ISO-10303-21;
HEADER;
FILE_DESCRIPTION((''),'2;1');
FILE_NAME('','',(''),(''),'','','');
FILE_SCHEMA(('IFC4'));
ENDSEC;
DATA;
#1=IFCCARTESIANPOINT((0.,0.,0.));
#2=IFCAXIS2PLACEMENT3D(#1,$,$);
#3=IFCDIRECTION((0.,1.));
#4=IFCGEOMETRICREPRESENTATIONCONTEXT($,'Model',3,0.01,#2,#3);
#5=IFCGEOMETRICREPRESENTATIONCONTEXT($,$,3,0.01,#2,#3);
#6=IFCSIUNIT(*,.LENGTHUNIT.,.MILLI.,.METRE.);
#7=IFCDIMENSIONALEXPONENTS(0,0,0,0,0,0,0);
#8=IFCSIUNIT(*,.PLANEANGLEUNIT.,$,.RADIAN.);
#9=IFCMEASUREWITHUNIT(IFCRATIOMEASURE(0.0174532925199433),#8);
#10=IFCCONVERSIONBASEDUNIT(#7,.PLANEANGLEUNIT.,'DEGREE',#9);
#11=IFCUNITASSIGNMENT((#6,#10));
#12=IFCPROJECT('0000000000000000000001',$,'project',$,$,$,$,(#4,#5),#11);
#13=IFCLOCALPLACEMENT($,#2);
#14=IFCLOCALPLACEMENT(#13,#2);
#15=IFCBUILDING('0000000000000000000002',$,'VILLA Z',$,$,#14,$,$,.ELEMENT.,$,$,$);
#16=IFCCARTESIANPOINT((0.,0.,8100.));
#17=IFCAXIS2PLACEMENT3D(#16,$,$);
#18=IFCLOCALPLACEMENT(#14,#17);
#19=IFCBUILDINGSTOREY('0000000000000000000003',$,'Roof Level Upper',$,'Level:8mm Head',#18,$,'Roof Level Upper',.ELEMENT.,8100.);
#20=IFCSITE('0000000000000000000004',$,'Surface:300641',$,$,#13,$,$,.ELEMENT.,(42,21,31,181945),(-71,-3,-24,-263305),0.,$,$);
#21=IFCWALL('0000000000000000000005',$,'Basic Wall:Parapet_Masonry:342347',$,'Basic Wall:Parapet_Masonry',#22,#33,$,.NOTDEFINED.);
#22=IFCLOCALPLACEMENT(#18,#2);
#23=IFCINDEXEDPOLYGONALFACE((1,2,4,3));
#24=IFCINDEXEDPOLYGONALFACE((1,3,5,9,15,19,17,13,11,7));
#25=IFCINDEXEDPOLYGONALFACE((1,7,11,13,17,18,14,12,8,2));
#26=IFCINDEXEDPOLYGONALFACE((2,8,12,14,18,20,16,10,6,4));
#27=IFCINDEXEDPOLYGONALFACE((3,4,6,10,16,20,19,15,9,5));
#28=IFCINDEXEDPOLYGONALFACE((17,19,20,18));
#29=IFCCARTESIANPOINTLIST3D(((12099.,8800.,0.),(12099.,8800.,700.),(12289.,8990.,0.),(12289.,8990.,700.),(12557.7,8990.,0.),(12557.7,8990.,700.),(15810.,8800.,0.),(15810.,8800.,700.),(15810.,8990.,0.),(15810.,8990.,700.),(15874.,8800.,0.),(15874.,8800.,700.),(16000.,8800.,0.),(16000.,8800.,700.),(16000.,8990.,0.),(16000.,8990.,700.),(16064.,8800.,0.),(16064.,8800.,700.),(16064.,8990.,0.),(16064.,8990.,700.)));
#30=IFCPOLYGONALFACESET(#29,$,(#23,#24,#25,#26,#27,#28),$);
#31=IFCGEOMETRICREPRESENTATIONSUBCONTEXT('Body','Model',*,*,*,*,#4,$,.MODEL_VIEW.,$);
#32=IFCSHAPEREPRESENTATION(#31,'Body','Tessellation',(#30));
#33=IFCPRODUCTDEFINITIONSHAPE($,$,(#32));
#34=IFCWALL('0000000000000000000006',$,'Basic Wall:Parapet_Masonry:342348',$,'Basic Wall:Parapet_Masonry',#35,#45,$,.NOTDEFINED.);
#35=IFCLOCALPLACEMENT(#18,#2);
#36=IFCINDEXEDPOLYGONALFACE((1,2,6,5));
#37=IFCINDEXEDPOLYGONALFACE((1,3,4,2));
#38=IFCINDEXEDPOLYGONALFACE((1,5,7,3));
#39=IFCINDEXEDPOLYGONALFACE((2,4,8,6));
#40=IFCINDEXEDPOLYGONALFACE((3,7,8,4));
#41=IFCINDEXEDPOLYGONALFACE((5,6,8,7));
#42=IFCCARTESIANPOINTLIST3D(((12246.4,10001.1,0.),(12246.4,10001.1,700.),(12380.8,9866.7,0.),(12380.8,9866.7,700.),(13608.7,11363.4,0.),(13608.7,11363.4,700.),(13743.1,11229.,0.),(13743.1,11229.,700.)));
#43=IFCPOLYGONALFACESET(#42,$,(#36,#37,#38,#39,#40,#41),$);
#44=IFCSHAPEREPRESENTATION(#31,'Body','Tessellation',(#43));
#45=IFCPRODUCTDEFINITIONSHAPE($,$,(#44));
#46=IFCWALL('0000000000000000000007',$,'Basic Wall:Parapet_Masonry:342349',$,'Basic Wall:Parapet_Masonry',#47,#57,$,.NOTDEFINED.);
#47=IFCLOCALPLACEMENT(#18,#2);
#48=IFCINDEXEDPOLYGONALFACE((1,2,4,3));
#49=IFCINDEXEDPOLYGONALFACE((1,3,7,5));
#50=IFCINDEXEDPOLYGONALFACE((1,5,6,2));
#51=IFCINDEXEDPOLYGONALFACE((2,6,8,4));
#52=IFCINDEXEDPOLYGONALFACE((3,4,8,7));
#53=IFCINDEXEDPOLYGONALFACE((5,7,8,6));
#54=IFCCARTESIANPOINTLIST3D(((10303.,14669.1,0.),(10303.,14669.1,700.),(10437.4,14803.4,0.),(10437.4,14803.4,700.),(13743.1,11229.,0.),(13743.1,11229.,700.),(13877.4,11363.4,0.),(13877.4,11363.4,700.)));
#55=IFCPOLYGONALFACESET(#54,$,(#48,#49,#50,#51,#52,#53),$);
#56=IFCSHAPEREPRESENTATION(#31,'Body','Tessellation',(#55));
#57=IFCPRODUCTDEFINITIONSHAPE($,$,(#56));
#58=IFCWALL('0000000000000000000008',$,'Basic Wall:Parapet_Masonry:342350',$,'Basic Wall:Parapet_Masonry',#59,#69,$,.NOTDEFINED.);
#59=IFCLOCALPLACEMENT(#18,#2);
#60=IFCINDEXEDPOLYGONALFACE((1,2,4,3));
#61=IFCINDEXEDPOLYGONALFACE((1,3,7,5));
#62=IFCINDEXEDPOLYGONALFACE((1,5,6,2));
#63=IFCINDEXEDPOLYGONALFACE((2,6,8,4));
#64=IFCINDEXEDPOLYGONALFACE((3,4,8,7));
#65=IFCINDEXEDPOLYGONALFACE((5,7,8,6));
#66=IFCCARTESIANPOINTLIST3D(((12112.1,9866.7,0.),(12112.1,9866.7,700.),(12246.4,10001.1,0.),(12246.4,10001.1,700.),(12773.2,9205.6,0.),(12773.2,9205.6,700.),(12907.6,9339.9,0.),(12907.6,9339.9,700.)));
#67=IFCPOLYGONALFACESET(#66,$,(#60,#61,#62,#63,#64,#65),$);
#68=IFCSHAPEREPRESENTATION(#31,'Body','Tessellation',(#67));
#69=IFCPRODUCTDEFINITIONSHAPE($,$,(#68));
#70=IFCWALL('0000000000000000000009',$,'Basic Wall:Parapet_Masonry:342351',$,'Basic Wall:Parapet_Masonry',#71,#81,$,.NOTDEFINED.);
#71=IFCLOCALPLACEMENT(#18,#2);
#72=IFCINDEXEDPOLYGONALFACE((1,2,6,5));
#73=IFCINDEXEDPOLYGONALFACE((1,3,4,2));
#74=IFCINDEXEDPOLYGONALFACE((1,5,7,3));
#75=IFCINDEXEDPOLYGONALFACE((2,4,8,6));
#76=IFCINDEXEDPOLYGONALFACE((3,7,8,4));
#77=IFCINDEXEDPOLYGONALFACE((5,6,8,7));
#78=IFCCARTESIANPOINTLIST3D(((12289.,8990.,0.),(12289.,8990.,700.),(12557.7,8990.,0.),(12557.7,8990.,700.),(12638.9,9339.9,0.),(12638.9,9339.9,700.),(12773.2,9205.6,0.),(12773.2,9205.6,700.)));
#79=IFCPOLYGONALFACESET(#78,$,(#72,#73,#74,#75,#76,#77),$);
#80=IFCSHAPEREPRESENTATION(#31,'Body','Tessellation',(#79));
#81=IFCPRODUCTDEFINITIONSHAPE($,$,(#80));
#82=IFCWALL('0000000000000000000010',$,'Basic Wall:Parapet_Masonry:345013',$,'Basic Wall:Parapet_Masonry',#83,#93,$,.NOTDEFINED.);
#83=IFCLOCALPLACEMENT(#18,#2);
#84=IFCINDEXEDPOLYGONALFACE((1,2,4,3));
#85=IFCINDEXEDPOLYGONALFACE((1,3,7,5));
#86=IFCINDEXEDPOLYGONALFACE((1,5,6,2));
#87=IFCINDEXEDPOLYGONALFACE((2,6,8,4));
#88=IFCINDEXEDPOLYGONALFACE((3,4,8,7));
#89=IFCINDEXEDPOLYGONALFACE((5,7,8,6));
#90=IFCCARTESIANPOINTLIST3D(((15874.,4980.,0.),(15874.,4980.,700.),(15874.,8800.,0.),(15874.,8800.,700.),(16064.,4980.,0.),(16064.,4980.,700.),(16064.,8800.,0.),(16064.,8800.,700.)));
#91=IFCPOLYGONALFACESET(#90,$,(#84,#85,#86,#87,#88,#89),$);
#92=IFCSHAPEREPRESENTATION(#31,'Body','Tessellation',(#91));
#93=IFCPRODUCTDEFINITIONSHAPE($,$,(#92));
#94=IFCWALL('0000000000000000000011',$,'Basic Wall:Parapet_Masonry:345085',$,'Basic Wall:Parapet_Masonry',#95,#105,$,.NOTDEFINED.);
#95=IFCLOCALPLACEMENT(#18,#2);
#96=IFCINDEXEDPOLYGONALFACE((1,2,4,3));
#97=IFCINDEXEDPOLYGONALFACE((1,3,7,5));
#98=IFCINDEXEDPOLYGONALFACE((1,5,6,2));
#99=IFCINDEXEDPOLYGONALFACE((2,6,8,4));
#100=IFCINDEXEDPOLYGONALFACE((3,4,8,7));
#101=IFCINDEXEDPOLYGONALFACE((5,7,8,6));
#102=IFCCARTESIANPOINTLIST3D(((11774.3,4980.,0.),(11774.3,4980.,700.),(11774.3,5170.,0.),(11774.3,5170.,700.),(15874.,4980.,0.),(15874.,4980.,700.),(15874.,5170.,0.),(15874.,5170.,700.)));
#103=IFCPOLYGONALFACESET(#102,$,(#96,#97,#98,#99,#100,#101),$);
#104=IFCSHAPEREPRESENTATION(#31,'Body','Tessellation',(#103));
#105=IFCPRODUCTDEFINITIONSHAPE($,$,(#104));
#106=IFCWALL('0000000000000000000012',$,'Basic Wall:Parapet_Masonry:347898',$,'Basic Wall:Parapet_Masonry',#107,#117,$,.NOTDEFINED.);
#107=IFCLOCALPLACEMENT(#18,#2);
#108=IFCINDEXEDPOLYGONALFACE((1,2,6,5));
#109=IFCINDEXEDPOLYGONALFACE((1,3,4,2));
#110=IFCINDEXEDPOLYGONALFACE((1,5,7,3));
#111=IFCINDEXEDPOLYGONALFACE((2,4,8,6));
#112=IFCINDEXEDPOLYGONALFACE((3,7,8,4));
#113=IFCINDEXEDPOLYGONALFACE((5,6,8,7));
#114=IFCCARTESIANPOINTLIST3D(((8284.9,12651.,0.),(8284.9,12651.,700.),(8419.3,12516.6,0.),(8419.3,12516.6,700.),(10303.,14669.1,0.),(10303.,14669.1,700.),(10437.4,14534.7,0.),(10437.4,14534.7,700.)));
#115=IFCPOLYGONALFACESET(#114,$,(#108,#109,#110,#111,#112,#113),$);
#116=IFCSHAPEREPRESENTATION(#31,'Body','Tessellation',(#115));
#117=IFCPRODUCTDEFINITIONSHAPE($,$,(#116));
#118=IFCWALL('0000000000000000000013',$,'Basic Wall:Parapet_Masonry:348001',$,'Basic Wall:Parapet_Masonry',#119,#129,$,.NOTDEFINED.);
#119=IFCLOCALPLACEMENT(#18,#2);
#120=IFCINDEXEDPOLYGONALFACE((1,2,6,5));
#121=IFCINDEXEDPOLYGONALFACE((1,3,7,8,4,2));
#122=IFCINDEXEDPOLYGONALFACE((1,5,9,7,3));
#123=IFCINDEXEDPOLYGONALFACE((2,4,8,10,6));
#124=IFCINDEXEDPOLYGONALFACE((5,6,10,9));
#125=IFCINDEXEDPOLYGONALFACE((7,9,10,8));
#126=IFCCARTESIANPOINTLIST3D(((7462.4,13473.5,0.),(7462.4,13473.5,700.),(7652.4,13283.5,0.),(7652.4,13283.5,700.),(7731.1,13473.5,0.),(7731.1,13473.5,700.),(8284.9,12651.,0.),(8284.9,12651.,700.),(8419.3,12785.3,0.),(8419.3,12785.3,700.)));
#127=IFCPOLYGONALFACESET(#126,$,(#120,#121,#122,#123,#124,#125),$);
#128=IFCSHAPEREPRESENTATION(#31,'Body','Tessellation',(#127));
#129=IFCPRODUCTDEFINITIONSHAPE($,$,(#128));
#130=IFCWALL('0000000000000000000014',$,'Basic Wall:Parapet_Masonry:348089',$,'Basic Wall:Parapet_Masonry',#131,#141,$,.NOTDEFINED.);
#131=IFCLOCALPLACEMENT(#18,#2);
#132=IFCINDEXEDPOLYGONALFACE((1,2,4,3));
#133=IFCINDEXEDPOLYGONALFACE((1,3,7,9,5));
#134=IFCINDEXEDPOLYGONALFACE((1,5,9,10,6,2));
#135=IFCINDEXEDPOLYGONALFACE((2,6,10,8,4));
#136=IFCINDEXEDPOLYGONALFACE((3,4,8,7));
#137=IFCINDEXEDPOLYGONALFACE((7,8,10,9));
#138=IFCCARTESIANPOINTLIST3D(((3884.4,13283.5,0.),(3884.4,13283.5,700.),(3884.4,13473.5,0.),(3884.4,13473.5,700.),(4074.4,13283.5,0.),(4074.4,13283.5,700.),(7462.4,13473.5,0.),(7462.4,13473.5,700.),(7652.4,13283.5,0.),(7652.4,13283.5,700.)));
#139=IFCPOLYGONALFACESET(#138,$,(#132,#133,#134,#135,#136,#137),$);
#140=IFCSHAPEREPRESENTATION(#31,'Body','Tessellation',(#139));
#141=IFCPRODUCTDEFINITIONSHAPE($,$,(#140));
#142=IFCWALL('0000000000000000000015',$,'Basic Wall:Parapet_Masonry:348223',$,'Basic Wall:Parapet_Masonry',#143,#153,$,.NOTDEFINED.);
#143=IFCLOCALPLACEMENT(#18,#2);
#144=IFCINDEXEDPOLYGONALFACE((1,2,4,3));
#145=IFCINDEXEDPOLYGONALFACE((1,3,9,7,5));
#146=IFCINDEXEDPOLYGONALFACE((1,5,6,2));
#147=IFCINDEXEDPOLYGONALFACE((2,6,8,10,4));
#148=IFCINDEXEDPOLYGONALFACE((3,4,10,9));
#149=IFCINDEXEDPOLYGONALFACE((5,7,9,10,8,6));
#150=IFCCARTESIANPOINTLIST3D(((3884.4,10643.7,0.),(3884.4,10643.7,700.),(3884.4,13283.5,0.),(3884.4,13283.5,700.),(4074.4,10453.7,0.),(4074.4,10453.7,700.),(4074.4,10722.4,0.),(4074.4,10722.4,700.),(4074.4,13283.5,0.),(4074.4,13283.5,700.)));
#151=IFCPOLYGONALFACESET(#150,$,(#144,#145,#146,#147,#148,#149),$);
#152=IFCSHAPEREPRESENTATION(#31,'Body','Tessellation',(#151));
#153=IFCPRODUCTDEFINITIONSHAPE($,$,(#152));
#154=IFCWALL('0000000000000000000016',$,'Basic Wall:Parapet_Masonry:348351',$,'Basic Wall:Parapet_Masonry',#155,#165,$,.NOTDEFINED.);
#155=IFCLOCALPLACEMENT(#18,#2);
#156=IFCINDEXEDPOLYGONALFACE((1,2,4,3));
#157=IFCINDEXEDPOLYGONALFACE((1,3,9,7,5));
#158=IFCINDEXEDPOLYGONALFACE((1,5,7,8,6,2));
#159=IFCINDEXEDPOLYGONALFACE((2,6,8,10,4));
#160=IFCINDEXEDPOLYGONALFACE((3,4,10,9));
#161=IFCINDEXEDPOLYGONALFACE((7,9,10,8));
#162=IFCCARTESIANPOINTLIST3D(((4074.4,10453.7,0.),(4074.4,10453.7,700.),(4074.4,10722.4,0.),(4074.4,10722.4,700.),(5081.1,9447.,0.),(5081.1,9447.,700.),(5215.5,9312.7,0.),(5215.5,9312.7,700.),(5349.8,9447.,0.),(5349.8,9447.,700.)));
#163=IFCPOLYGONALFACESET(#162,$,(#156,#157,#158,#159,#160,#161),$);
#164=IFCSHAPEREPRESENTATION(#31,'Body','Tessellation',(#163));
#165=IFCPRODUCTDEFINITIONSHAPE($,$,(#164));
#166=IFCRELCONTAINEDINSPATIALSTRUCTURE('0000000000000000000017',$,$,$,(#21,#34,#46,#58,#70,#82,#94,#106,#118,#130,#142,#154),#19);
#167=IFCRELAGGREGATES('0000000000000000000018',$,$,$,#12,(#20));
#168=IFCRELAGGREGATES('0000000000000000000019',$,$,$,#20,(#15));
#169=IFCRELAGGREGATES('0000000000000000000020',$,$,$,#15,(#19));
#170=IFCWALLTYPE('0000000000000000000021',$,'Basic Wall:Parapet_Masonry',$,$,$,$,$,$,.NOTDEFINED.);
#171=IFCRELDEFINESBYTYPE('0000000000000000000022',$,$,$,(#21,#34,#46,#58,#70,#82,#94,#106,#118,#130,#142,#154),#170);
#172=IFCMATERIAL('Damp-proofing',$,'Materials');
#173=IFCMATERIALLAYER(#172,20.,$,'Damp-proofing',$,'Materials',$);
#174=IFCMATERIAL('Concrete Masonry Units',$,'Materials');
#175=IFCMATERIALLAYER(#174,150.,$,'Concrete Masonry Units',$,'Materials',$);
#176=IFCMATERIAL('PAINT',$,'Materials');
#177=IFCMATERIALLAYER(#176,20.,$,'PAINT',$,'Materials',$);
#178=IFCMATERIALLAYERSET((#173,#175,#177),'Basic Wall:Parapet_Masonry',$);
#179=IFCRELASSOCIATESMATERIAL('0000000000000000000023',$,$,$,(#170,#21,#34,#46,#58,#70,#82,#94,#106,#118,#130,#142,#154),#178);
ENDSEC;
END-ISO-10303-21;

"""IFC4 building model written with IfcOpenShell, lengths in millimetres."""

from ifc_helpers import new_model, entity, si_unit, converted_unit, direction, frame, frame_2d, origin, place, context, subcontext, project, spatial, polyline, rectangle, outline, extrude, material, layer, layer_set, layer_usage, type_object, element, save


model = new_model("IFC4")

# Units and contexts
model_context = context("Model", 3, precision=0.01, world=origin(), true_north=direction((0.0, 1.0)))
context_of_model = context(None, 3, precision=0.01, world=origin(), true_north=direction((0.0, 1.0)))
body_context = subcontext(model_context, "Body", "Model", "MODEL_VIEW")
ifc_project = project(units=[si_unit("LENGTHUNIT", "METRE", prefix="MILLI"), converted_unit("PLANEANGLEUNIT", "DEGREE", entity("IfcRatioMeasure", 0.0174532925199433), si_unit("PLANEANGLEUNIT", "RADIAN"), dimensions=[0, 0, 0, 0, 0, 0, 0])], contexts=[model_context, context_of_model])

# Site, building, storey
site_placement = place(None, origin())
site = spatial("IfcSite", under=ifc_project, at=site_placement, Name="Surface:300641", CompositionType="ELEMENT", RefLatitude=(42, 21, 31, 181945), RefLongitude=(-71, -3, -24, -263305), RefElevation=0.0)
building_placement = place(site_placement, origin())
building = spatial("IfcBuilding", under=site, at=building_placement, Name="VILLA Z", CompositionType="ELEMENT")
storey_placement = place(building_placement, frame((0.0, 0.0, 8100.0)))
storey = spatial("IfcBuildingStorey", under=building, at=storey_placement, Name="Roof Level Upper", ObjectType="Level:8mm Head", LongName="Roof Level Upper", CompositionType="ELEMENT", Elevation=8100.0)

# Shared definitions
ifc_material_1 = material(Name="Damp-proofing", Category="Materials")

# Walls
ifc_layer_1 = layer(ifc_material_1, 20.0, Name="Damp-proofing", Category="Materials")
ifc_material_2 = material(Name="Concrete Masonry Units", Category="Materials")
ifc_layer_2 = layer(ifc_material_2, 150.0, Name="Concrete Masonry Units", Category="Materials")
ifc_material_3 = material(Name="PAINT", Category="Materials")
ifc_layer_3 = layer(ifc_material_3, 20.0, Name="PAINT", Category="Materials")
ifc_layer_set_1 = layer_set([ifc_layer_1, ifc_layer_2, ifc_layer_3], Name="Basic Wall:Parapet_Masonry")
ifc_layer_usage_1 = layer_usage(ifc_layer_set_1, "AXIS2", "NEGATIVE", 95.0)
wall_type = type_object("IfcWallType", Name="Basic Wall:Parapet_Masonry", PredefinedType="NOTDEFINED", material=ifc_layer_set_1)
wall_1_placement = place(storey_placement, frame((16064.0, 8895.0, 0.0), z_axis=(0.0, 0.0, 1.0), x_axis=(-1.0, 0.0, 0.0)))
element("IfcWall", 1, at=wall_1_placement, inside=storey, type_object=wall_type, material=ifc_layer_usage_1, Name="Basic Wall:Parapet_Masonry:342347", ObjectType="Basic Wall:Parapet_Masonry", PredefinedType="NOTDEFINED", context=body_context, shape_type="SweptSolid", body=[
    extrude(outline(polyline([(3775.0, -95.0), (3965.0, 95.0), (254.0, 95.0), (190.0, 95.0), (64.0, 95.0), (0.0, 95.0), (0.0, -95.0), (64.0, -95.0), (254.0, -95.0), (3506.3, -95.0), (3775.0, -95.0)])), origin(), (0.0, 0.0, 1.0), 700.0),
])
ifc_layer_usage_2 = layer_usage(ifc_layer_set_1, "AXIS2", "POSITIVE", -95.0)
wall_2_placement = place(storey_placement, frame((13675.9, 11296.2, 0.0), z_axis=(0.0, 0.0, 1.0), x_axis=(-0.707107, -0.707107, 0.0)))
element("IfcWall", 2, at=wall_2_placement, inside=storey, type_object=wall_type, material=ifc_layer_usage_2, Name="Basic Wall:Parapet_Masonry:342348", ObjectType="Basic Wall:Parapet_Masonry", PredefinedType="NOTDEFINED", context=body_context, shape_type="SweptSolid", body=[
    extrude(rectangle(XDim=1926.6, YDim=190.0, at=frame_2d((963.3, 0.0), x_axis=(-1.0, 0.0))), origin(), (0.0, 0.0, 1.0), 700.0),
])
ifc_layer_usage_3 = layer_usage(ifc_layer_set_1, "AXIS2", "POSITIVE", -95.0)
wall_3_placement = place(storey_placement, frame((10370.2, 14736.3, 0.0), z_axis=(0.0, 0.0, 1.0), x_axis=(0.707107, -0.707107, 0.0)))
element("IfcWall", 3, at=wall_3_placement, inside=storey, type_object=wall_type, material=ifc_layer_usage_3, Name="Basic Wall:Parapet_Masonry:342349", ObjectType="Basic Wall:Parapet_Masonry", PredefinedType="NOTDEFINED", context=body_context, shape_type="SweptSolid", body=[
    extrude(rectangle(XDim=4865.0, YDim=190.0, at=frame_2d((2432.5, 0.0), x_axis=(-1.0, 0.0))), origin(), (0.0, 0.0, 1.0), 700.0),
])
ifc_layer_usage_4 = layer_usage(ifc_layer_set_1, "AXIS2", "POSITIVE", -95.0)
wall_4_placement = place(storey_placement, frame((12179.3, 9933.9, 0.0), z_axis=(0.0, 0.0, 1.0), x_axis=(0.707107, -0.707107, 0.0)))
element("IfcWall", 4, at=wall_4_placement, inside=storey, type_object=wall_type, material=ifc_layer_usage_4, Name="Basic Wall:Parapet_Masonry:342350", ObjectType="Basic Wall:Parapet_Masonry", PredefinedType="NOTDEFINED", context=body_context, shape_type="SweptSolid", body=[
    extrude(rectangle(XDim=935.0, YDim=190.0, at=frame_2d((467.5, 0.0), x_axis=(-1.0, 0.0))), origin(), (0.0, 0.0, 1.0), 700.0),
])
ifc_layer_usage_5 = layer_usage(ifc_layer_set_1, "AXIS2", "POSITIVE", -95.0)
wall_5_placement = place(storey_placement, frame((12706.1, 9272.7, 0.0), z_axis=(0.0, 0.0, 1.0), x_axis=(-0.707107, -0.707107, 0.0)))
element("IfcWall", 5, at=wall_5_placement, inside=storey, type_object=wall_type, material=ifc_layer_usage_5, Name="Basic Wall:Parapet_Masonry:342351", ObjectType="Basic Wall:Parapet_Masonry", PredefinedType="NOTDEFINED", context=body_context, shape_type="SweptSolid", body=[
    extrude(outline(polyline([(494.8, -95.0), (304.8, 95.0), (0.0, 95.0), (0.0, -95.0), (494.8, -95.0)])), origin(), (0.0, 0.0, 1.0), 700.0),
])
ifc_layer_usage_6 = layer_usage(ifc_layer_set_1, "AXIS2", "POSITIVE", -95.0)
wall_6_placement = place(storey_placement, frame((15969.0, 8800.0, 0.0), z_axis=(0.0, 0.0, 1.0), x_axis=(0.0, -1.0, 0.0)))
element("IfcWall", 6, at=wall_6_placement, inside=storey, type_object=wall_type, material=ifc_layer_usage_6, Name="Basic Wall:Parapet_Masonry:345013", ObjectType="Basic Wall:Parapet_Masonry", PredefinedType="NOTDEFINED", context=body_context, shape_type="SweptSolid", body=[
    extrude(rectangle(XDim=3820.0, YDim=190.0, at=frame_2d((1910.0, 0.0), x_axis=(-1.0, 0.0))), origin(), (0.0, 0.0, 1.0), 700.0),
])
ifc_layer_usage_7 = layer_usage(ifc_layer_set_1, "AXIS2", "NEGATIVE", 95.0)
wall_7_placement = place(storey_placement, frame((11774.3, 5075.0, 0.0)))
element("IfcWall", 7, at=wall_7_placement, inside=storey, type_object=wall_type, material=ifc_layer_usage_7, Name="Basic Wall:Parapet_Masonry:345085", ObjectType="Basic Wall:Parapet_Masonry", PredefinedType="NOTDEFINED", context=body_context, shape_type="SweptSolid", body=[
    extrude(rectangle(XDim=4099.7, YDim=190.0, at=frame_2d((2049.9, 0.0), x_axis=(-1.0, 0.0))), origin(), (0.0, 0.0, 1.0), 700.0),
])
ifc_layer_usage_8 = layer_usage(ifc_layer_set_1, "AXIS2", "NEGATIVE", 95.0)
wall_8_placement = place(storey_placement, frame((10370.2, 14601.9, 0.0), z_axis=(0.0, 0.0, 1.0), x_axis=(-0.707107, -0.707107, 0.0)))
element("IfcWall", 8, at=wall_8_placement, inside=storey, type_object=wall_type, material=ifc_layer_usage_8, Name="Basic Wall:Parapet_Masonry:347898", ObjectType="Basic Wall:Parapet_Masonry", PredefinedType="NOTDEFINED", context=body_context, shape_type="SweptSolid", body=[
    extrude(rectangle(XDim=2854.0, YDim=190.0, at=frame_2d((1427.0, 0.0), x_axis=(-1.0, 0.0))), origin(), (0.0, 0.0, 1.0), 700.0),
])
ifc_layer_usage_9 = layer_usage(ifc_layer_set_1, "AXIS2", "POSITIVE", -95.0)
wall_9_placement = place(storey_placement, frame((7529.6, 13540.6, 0.0), z_axis=(0.0, 0.0, 1.0), x_axis=(0.707107, -0.707107, 0.0)))
element("IfcWall", 9, at=wall_9_placement, inside=storey, type_object=wall_type, material=ifc_layer_usage_9, Name="Basic Wall:Parapet_Masonry:348001", ObjectType="Basic Wall:Parapet_Masonry", PredefinedType="NOTDEFINED", context=body_context, shape_type="SweptSolid", body=[
    extrude(outline(polyline([(1163.2, -95.0), (1163.2, 95.0), (190.0, 95.0), (0.0, -95.0), (268.7, -95.0), (1163.2, -95.0)])), origin(), (0.0, 0.0, 1.0), 700.0),
])
ifc_layer_usage_10 = layer_usage(ifc_layer_set_1, "AXIS2", "NEGATIVE", 95.0)
wall_10_placement = place(storey_placement, frame((7652.4, 13378.5, 0.0), z_axis=(0.0, 0.0, 1.0), x_axis=(-1.0, 0.0, 0.0)))
element("IfcWall", 10, at=wall_10_placement, inside=storey, type_object=wall_type, material=ifc_layer_usage_10, Name="Basic Wall:Parapet_Masonry:348089", ObjectType="Basic Wall:Parapet_Masonry", PredefinedType="NOTDEFINED", context=body_context, shape_type="SweptSolid", body=[
    extrude(outline(polyline([(3768.0, -95.0), (3768.0, 95.0), (3578.0, 95.0), (0.0, 95.0), (190.0, -95.0), (3768.0, -95.0)])), origin(), (0.0, 0.0, 1.0), 700.0),
])
ifc_layer_usage_11 = layer_usage(ifc_layer_set_1, "AXIS2", "NEGATIVE", 95.0)
wall_11_placement = place(storey_placement, frame((3979.4, 13283.5, 0.0), z_axis=(0.0, 0.0, 1.0), x_axis=(0.0, -1.0, 0.0)))
element("IfcWall", 11, at=wall_11_placement, inside=storey, type_object=wall_type, material=ifc_layer_usage_11, Name="Basic Wall:Parapet_Masonry:348223", ObjectType="Basic Wall:Parapet_Masonry", PredefinedType="NOTDEFINED", context=body_context, shape_type="SweptSolid", body=[
    extrude(outline(polyline([(2639.8, -95.0), (2829.8, 95.0), (2561.1, 95.0), (0.0, 95.0), (0.0, -95.0), (2639.8, -95.0)])), origin(), (0.0, 0.0, 1.0), 700.0),
])
ifc_layer_usage_12 = layer_usage(ifc_layer_set_1, "AXIS2", "NEGATIVE", 95.0)
wall_12_placement = place(storey_placement, frame((4007.3, 10655.2, 0.0), z_axis=(0.0, 0.0, 1.0), x_axis=(0.707107, -0.707107, 0.0)))
element("IfcWall", 12, at=wall_12_placement, inside=storey, type_object=wall_type, material=ifc_layer_usage_12, Name="Basic Wall:Parapet_Masonry:348351", ObjectType="Basic Wall:Parapet_Masonry", PredefinedType="NOTDEFINED", context=body_context, shape_type="SweptSolid", body=[
    extrude(outline(polyline([(1803.7, -95.0), (1803.7, 95.0), (0.0, 95.0), (190.0, -95.0), (1613.7, -95.0), (1803.7, -95.0)])), origin(), (0.0, 0.0, 1.0), 700.0),
])

save(model, "model.ifc")
